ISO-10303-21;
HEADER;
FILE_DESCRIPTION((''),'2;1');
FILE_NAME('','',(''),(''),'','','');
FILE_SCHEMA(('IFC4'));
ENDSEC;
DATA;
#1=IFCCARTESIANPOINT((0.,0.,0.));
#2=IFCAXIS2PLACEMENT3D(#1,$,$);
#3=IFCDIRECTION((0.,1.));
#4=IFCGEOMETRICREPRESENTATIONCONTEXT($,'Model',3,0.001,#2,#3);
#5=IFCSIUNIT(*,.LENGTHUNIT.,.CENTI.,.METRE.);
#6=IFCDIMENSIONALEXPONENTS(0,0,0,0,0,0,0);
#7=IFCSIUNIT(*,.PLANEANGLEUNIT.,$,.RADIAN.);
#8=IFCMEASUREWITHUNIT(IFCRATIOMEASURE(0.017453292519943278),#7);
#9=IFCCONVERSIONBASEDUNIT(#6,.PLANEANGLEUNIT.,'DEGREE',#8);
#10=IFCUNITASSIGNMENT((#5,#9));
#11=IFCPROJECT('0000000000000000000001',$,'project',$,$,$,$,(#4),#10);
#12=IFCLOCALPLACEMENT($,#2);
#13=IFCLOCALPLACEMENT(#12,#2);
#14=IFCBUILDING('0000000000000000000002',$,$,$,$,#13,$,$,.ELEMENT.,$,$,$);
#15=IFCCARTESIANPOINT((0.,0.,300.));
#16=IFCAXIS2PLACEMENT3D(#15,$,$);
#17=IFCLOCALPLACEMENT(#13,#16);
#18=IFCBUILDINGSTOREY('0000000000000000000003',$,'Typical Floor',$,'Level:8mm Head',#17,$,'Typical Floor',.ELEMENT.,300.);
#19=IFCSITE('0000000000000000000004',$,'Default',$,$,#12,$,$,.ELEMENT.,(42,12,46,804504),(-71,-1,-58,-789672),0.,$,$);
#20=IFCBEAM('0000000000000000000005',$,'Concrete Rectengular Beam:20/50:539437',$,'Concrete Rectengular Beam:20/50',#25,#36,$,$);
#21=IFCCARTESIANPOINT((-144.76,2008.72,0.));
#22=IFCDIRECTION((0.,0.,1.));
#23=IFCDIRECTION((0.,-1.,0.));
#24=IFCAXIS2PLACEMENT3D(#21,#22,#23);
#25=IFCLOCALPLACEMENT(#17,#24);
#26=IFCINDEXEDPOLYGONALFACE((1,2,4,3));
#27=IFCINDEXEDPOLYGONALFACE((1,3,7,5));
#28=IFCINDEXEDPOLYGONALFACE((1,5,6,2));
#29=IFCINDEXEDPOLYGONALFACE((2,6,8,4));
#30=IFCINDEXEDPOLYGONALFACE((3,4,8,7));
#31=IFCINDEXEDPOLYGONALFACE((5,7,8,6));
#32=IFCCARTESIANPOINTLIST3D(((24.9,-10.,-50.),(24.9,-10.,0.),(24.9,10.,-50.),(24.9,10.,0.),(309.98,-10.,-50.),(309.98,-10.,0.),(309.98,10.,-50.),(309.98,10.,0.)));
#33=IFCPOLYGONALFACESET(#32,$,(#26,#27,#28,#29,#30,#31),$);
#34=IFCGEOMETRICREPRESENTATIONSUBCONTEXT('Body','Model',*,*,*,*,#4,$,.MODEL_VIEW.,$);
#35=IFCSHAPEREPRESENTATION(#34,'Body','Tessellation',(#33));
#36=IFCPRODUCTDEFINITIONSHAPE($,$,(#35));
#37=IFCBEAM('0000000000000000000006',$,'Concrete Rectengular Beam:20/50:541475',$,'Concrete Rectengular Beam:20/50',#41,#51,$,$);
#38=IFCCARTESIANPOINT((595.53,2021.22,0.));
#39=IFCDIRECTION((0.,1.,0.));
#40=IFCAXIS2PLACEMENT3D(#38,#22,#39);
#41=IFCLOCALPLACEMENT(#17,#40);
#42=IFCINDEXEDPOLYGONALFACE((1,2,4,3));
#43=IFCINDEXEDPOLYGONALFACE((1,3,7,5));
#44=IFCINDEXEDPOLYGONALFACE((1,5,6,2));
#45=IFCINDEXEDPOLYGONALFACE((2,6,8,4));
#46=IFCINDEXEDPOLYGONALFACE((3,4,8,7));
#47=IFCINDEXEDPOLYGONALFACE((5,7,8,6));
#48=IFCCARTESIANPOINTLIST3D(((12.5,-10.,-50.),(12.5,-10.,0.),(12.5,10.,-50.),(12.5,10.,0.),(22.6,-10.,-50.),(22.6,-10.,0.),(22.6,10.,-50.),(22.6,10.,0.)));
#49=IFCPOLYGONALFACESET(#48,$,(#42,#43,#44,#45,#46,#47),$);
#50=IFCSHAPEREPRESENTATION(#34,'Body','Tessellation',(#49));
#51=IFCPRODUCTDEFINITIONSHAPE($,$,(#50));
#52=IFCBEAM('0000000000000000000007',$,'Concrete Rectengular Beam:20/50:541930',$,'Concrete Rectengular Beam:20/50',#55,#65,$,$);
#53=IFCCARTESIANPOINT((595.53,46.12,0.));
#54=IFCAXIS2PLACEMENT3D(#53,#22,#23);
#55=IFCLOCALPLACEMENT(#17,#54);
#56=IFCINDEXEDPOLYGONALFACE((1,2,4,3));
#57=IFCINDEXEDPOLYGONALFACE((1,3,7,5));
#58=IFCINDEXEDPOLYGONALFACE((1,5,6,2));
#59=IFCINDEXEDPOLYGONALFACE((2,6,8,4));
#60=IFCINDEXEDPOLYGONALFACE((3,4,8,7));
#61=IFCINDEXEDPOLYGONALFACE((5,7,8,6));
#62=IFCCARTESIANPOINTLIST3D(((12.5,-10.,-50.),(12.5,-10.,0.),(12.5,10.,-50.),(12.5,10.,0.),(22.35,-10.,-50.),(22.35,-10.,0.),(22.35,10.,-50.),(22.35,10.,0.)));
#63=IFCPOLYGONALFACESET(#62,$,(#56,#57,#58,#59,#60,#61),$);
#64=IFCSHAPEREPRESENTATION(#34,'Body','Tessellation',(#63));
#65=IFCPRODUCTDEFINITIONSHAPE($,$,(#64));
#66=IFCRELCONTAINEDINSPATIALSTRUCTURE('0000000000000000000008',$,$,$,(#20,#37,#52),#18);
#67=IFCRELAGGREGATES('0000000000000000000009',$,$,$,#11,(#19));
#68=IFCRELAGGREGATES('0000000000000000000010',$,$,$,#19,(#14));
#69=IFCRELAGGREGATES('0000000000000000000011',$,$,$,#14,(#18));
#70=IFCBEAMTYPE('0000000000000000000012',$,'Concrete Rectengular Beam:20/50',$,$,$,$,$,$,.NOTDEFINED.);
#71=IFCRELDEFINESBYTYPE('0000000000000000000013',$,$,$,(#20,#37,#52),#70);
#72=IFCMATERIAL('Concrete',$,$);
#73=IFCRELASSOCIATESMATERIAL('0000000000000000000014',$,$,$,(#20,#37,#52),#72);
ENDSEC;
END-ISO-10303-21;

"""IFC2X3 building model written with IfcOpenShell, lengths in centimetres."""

from ifc_helpers import new_model, entity, si_unit, converted_unit, direction, frame, frame_2d, origin, place, context, subcontext, project, spatial, rectangle, extrude, material, type_object, element, save


model = new_model("IFC2X3")

# Units and contexts
model_context = context("Model", 3, precision=0.001, world=origin(), true_north=direction((0.0, 1.0)))
body_context = subcontext(model_context, "Body", "Model", "MODEL_VIEW")
ifc_project = project(units=[si_unit("LENGTHUNIT", "METRE", prefix="CENTI"), converted_unit("PLANEANGLEUNIT", "DEGREE", entity("IfcRatioMeasure", 0.017453292519943278), si_unit("PLANEANGLEUNIT", "RADIAN"), dimensions=[0, 0, 0, 0, 0, 0, 0])], contexts=[model_context])

# Site, building, storey
site_placement = place(None, origin())
site = spatial("IfcSite", under=ifc_project, at=site_placement, Name="Default", CompositionType="ELEMENT", RefLatitude=(42, 12, 46, 804504), RefLongitude=(-71, -1, -58, -789672), RefElevation=0.0)
building_placement = place(site_placement, origin())
building = spatial("IfcBuilding", under=site, at=building_placement, CompositionType="ELEMENT")
storey_placement = place(building_placement, frame((0.0, 0.0, 300.0)))
storey = spatial("IfcBuildingStorey", under=building, at=storey_placement, Name="Typical Floor", ObjectType="Level:8mm Head", LongName="Typical Floor", CompositionType="ELEMENT", Elevation=300.0)

# Beams
ifc_material = material(Name="Concrete")
beam_type_1 = type_object("IfcBeamType", Name="Concrete Rectengular Beam:20/50", PredefinedType="NOTDEFINED")
beam_1_placement = place(storey_placement, frame((-144.76, 2008.72, 0.0), z_axis=(0.0, 0.0, 1.0), x_axis=(0.0, -1.0, 0.0)))
element("IfcBeam", 1, at=beam_1_placement, inside=storey, type_object=beam_type_1, material=ifc_material, Name="Concrete Rectengular Beam:20/50:539437", ObjectType="Concrete Rectengular Beam:20/50", context=body_context, shape_type="SweptSolid", body=[
    extrude(rectangle(XDim=50.0, YDim=20.0, at=frame_2d((0.0, 0.0), x_axis=(1.0, 0.0))), frame((24.9, 0.0, -25.0), z_axis=(1.0, 0.0, 0.0), x_axis=(0.0, 0.0, -1.0)), (0.0, 0.0, 1.0), 285.08),
])
beam_2_placement = place(storey_placement, frame((595.53, 2021.22, 0.0), z_axis=(0.0, 0.0, 1.0), x_axis=(0.0, 1.0, 0.0)))
element("IfcBeam", 2, at=beam_2_placement, inside=storey, type_object=beam_type_1, material=ifc_material, Name="Concrete Rectengular Beam:20/50:541475", ObjectType="Concrete Rectengular Beam:20/50", context=body_context, shape_type="SweptSolid", body=[
    extrude(rectangle(XDim=50.0, YDim=20.0, at=frame_2d((0.0, 0.0), x_axis=(1.0, 0.0))), frame((12.5, 0.0, -25.0), z_axis=(1.0, 0.0, 0.0), x_axis=(0.0, 0.0, -1.0)), (0.0, 0.0, 1.0), 10.1),
])
beam_3_placement = place(storey_placement, frame((595.53, 46.12, 0.0), z_axis=(0.0, 0.0, 1.0), x_axis=(0.0, -1.0, 0.0)))
element("IfcBeam", 3, at=beam_3_placement, inside=storey, type_object=beam_type_1, material=ifc_material, Name="Concrete Rectengular Beam:20/50:541930", ObjectType="Concrete Rectengular Beam:20/50", context=body_context, shape_type="SweptSolid", body=[
    extrude(rectangle(XDim=50.0, YDim=20.0, at=frame_2d((0.0, 0.0), x_axis=(1.0, 0.0))), frame((12.5, 0.0, -25.0), z_axis=(1.0, 0.0, 0.0), x_axis=(0.0, 0.0, -1.0)), (0.0, 0.0, 1.0), 9.85),
])

save(model, "model.ifc")
